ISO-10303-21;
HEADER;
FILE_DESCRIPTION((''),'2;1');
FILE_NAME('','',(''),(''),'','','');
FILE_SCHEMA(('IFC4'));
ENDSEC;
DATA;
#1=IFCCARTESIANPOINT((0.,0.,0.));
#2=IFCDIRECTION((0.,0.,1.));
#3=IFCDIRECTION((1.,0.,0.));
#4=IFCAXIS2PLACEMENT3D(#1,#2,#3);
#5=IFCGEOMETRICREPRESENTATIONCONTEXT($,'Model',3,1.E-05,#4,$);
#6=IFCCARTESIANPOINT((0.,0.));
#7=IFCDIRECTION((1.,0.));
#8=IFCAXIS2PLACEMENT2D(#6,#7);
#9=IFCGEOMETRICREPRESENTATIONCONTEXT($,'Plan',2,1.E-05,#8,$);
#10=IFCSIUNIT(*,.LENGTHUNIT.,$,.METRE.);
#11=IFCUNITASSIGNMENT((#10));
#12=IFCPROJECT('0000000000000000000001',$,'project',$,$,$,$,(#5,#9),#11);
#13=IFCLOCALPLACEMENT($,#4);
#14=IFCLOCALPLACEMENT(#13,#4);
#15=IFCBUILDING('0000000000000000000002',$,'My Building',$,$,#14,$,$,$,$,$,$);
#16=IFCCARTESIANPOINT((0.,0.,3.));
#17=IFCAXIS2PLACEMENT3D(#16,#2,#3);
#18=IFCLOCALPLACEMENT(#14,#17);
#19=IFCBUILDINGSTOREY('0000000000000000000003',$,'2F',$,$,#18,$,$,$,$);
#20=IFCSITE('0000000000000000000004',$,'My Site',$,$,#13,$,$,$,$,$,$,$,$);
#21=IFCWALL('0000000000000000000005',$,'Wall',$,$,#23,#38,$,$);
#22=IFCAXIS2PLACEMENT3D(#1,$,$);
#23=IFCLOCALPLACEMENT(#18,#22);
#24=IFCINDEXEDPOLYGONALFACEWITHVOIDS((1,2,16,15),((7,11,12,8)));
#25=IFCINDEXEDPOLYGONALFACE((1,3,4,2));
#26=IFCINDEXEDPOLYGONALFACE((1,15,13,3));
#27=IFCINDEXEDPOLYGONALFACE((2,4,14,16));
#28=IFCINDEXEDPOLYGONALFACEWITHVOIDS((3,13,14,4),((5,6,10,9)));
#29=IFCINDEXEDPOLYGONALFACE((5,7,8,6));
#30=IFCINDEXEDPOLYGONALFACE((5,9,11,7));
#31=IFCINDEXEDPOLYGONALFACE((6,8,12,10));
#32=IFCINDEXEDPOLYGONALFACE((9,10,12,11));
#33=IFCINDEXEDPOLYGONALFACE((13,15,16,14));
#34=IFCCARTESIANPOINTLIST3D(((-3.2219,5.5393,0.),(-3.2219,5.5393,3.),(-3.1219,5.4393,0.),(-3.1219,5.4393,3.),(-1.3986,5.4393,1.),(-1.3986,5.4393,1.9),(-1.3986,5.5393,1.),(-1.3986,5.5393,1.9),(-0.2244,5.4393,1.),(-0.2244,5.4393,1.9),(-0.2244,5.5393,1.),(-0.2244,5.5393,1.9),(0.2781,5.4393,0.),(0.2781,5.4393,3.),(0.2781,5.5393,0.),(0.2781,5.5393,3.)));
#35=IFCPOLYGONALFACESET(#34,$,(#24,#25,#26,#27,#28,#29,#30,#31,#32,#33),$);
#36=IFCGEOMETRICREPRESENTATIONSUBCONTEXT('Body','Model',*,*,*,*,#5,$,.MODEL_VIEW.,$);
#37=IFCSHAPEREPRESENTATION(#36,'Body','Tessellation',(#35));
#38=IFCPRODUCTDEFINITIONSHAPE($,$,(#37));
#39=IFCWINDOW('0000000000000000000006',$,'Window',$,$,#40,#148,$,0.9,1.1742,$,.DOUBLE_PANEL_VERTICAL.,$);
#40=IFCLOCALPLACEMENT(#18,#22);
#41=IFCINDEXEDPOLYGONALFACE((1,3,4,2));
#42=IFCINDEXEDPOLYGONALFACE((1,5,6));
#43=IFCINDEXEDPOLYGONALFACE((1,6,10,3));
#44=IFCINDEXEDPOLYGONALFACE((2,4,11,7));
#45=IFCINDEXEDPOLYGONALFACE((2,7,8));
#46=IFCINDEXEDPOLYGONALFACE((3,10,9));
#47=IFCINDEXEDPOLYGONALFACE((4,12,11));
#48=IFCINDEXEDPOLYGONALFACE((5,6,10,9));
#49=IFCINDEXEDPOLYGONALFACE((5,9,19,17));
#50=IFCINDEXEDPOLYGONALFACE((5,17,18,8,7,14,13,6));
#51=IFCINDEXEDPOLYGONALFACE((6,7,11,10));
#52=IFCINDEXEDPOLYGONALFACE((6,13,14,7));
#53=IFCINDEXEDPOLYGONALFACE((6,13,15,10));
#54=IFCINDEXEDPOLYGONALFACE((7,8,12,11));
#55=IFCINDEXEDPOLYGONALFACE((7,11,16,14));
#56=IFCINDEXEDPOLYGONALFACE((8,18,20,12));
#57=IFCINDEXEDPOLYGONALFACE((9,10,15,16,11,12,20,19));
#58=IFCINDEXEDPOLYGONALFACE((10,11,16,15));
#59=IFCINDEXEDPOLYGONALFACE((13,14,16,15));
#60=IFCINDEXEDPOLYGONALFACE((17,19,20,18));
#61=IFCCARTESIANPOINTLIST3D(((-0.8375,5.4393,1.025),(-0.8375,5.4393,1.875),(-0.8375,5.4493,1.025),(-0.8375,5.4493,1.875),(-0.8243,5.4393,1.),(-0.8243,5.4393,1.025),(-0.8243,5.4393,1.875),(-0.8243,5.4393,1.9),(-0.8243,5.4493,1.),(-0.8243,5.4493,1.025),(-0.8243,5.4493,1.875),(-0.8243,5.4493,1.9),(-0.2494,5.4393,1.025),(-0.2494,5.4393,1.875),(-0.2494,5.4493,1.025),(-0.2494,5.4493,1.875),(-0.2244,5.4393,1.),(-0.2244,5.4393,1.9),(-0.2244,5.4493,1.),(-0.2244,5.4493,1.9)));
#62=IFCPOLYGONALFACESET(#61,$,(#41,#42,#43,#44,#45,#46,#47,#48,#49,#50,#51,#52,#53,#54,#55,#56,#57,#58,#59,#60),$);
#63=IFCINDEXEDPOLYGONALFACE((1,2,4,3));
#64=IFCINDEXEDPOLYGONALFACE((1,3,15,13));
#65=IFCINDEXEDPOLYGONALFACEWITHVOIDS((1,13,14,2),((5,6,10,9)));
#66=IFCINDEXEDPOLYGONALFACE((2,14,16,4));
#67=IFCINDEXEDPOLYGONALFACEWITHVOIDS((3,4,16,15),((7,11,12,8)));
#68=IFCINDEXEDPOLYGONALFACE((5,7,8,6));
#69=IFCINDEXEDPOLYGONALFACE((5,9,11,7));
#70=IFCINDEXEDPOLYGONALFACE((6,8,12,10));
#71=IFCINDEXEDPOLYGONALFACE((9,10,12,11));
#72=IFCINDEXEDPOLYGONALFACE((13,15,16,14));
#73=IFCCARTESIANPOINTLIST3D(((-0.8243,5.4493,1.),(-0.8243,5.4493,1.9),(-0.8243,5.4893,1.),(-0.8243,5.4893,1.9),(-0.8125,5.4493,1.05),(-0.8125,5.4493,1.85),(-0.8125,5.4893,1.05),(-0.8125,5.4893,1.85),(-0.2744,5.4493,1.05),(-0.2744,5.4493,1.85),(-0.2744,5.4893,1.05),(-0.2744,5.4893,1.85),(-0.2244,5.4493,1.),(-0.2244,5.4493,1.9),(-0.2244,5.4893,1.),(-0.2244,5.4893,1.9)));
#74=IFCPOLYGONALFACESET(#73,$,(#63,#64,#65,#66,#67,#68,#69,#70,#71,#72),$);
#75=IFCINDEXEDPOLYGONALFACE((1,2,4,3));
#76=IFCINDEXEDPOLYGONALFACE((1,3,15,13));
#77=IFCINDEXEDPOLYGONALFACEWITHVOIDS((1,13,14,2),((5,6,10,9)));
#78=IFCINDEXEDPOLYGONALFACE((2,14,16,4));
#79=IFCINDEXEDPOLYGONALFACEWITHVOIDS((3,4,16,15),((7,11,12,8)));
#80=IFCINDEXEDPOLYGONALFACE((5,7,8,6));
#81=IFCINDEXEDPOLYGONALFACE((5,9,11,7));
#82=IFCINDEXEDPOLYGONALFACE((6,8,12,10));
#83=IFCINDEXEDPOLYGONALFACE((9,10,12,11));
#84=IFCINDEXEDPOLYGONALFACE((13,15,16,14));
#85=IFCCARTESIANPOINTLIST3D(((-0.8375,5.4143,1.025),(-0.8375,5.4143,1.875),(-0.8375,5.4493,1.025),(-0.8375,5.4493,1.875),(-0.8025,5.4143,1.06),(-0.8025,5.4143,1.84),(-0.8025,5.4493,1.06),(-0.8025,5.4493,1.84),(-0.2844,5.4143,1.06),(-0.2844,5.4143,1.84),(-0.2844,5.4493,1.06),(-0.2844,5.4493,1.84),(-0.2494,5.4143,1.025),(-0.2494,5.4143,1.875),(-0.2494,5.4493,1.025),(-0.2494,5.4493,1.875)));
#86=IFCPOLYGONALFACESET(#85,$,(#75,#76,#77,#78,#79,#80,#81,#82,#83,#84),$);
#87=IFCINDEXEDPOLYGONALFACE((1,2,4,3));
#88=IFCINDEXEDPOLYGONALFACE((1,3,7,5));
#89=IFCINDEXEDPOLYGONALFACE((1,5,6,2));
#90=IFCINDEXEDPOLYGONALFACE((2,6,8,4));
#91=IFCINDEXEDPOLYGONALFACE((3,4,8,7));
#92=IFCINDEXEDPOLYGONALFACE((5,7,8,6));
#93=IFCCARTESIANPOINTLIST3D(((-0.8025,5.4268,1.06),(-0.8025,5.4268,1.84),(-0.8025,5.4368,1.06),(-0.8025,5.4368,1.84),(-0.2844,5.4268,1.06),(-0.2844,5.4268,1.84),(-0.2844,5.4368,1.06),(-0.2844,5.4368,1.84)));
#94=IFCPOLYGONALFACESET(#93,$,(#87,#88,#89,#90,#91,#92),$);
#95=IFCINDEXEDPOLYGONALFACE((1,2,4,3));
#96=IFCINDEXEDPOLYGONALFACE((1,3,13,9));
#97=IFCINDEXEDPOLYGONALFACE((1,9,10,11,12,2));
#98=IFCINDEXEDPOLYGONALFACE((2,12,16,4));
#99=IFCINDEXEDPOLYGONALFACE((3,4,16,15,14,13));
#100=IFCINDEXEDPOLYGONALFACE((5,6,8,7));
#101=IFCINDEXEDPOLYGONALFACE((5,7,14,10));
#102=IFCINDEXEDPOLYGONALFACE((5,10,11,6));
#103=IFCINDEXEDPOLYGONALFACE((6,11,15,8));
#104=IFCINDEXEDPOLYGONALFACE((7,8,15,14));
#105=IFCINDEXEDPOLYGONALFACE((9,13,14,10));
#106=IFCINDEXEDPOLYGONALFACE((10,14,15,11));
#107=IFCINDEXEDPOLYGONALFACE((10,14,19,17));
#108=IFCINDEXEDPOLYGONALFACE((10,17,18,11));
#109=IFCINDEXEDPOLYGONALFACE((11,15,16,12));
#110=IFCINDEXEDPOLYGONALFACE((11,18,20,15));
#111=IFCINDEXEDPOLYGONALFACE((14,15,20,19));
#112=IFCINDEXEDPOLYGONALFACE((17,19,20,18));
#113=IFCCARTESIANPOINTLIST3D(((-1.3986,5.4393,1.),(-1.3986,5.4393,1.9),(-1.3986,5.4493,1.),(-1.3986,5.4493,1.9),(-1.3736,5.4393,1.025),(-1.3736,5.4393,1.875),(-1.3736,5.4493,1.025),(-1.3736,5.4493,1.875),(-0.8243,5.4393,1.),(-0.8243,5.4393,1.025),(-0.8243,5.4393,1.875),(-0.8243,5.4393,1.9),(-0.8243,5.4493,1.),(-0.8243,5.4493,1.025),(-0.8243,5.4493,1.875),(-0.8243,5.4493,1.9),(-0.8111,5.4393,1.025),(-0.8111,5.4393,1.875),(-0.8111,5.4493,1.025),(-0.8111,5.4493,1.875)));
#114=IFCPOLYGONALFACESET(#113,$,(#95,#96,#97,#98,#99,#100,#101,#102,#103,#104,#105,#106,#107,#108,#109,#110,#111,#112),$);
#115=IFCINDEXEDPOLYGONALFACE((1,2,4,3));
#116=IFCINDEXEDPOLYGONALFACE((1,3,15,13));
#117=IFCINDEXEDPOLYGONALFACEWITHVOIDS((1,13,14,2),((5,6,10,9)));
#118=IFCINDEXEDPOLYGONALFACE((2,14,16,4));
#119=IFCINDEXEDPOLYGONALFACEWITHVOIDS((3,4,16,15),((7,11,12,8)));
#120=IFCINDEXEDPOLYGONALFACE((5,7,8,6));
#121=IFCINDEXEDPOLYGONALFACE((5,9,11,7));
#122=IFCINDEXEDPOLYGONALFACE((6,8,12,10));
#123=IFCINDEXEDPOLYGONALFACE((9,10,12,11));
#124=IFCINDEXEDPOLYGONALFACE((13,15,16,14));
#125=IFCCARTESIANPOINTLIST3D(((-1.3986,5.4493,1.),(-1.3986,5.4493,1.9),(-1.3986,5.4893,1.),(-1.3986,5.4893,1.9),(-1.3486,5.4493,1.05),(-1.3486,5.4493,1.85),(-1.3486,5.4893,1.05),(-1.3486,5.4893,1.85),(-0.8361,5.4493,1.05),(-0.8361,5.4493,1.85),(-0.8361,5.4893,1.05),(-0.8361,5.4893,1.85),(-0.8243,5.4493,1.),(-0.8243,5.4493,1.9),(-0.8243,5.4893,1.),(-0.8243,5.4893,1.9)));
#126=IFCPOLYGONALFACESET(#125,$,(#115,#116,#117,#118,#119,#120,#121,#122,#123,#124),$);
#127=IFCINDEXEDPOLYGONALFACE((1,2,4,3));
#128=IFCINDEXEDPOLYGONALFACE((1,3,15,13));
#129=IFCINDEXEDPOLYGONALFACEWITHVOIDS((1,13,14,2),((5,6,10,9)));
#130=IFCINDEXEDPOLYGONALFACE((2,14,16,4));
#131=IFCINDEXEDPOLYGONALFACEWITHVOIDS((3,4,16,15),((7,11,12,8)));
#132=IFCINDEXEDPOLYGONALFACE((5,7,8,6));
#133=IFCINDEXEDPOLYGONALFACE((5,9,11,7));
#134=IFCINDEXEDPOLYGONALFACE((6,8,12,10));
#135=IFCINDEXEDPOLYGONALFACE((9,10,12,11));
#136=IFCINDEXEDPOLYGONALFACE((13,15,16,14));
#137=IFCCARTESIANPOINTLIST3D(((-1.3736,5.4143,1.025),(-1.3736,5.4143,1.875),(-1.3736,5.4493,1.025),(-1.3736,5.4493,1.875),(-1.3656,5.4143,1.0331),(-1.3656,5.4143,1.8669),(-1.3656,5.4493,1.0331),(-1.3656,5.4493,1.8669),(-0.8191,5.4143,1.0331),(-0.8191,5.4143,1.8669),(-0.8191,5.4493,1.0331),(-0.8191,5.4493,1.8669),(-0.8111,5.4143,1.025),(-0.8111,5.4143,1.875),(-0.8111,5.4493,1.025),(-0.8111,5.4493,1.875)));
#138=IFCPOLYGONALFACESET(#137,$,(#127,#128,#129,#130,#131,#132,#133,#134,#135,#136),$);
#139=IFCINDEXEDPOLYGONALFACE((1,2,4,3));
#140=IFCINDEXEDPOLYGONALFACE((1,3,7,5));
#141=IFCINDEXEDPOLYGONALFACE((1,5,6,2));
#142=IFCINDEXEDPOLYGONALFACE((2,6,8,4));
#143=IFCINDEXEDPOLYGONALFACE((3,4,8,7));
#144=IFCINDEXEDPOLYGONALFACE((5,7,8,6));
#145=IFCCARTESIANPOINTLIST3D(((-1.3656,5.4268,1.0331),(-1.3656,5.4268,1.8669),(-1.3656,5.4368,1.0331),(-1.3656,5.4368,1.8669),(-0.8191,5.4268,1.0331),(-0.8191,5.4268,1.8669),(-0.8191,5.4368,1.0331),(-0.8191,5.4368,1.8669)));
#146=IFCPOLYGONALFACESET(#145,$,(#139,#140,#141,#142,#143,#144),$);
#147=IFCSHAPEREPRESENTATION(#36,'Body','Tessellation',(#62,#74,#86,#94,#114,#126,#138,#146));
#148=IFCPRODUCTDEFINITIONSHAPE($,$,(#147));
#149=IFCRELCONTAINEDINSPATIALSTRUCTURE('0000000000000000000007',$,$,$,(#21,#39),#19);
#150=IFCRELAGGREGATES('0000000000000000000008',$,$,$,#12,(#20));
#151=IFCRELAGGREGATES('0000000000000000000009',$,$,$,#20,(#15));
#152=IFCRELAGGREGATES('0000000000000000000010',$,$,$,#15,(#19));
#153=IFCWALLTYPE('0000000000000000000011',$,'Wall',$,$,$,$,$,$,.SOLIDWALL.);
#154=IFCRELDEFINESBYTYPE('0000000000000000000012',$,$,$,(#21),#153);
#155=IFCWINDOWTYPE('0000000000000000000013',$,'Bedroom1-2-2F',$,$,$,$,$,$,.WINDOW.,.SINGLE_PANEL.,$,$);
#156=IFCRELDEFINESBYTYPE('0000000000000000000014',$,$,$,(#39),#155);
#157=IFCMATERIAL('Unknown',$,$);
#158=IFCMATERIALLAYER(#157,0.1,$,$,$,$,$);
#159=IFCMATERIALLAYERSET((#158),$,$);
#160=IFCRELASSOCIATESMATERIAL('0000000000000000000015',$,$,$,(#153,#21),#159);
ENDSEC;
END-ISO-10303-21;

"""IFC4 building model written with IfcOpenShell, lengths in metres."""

from ifc_helpers import new_model, entity, si_unit, frame, origin_with_axes, origin_2d_with_axis, place, context, subcontext, project, spatial, line, indexed_curve, outline, extrude, shape, source, transform, mapped, material, layer, layer_set, layer_usage, type_object, type_shapes, element, fill, save


model = new_model("IFC4")

# Units and contexts
model_context = context("Model", 3, precision=1e-05, world=origin_with_axes())
plan_context = context("Plan", 2, precision=1e-05, world=origin_2d_with_axis())
body_context_1 = subcontext(model_context, "Body", "Model", "MODEL_VIEW")
body_context_2 = subcontext(plan_context, "Body", "Plan", "PLAN_VIEW")
ifc_project = project(units=[si_unit("LENGTHUNIT", "METRE")], contexts=[model_context, plan_context])

# Site, building, storey
site_placement = place(None, origin_with_axes())
site = spatial("IfcSite", under=ifc_project, at=site_placement, Name="My Site")
building_placement = place(site_placement, origin_with_axes())
building = spatial("IfcBuilding", under=site, at=building_placement, Name="My Building")
storey_placement = place(building_placement, frame((0.0, 0.0, 3.0), z_axis=(0.0, 0.0, 1.0), x_axis=(1.0, 0.0, 0.0)))
storey = spatial("IfcBuildingStorey", under=building, at=storey_placement, Name="2F")

# Shared definitions
ifc_material = material(Name="Unknown")

# Shared definitions
ifc_layer_1 = layer(ifc_material, 0.1)
ifc_layer_set_1 = layer_set([ifc_layer_1])
wall_type = type_object("IfcWallType", Name="Wall", PredefinedType="SOLIDWALL", material=ifc_layer_set_1)

# Wall, opening, window
ifc_layer_usage_1 = layer_usage(ifc_layer_set_1, "AXIS2", "POSITIVE", 0.0)
wall_1_placement = place(storey_placement, frame((0.2781, 5.5393, 0.0), z_axis=(0.0, 0.0, 1.0), x_axis=(-1.0, 0.0, 0.0)))
wall_1 = element("IfcWall", 1, at=wall_1_placement, inside=storey, type_object=wall_type, material=ifc_layer_usage_1, Name="Wall", context=body_context_1, shape_type="SweptSolid", body=[
    extrude(outline(indexed_curve([(0.0, 0.0), (0.0, 0.1), (3.4, 0.1), (3.5, 0.0)], segments=[line(1, 2, 3, 4, 1)])), origin_with_axes(), (0.0, 0.0, 1.0), 3.0),
])
shared_shape_1 = source(origin_with_axes(), body_context_1, "Body", "SweptSolid", [
    extrude(outline(indexed_curve([(0.0, 0.0), (1.1742, 0.0), (1.1742, 0.9), (0.0, 0.9)], segments=[line(1, 2, 3, 4, 1)])), frame((0.0, -0.6, 0.0), z_axis=(0.0, -1.0, 0.0), x_axis=(1.0, 0.0, 0.0)), (0.0, 0.0, -1.0), 1.2),
])
opening_1_placement = place(wall_1_placement, frame((0.5025, 0.0, 1.0), z_axis=(0.0, 0.0, 1.0), x_axis=(1.0, 0.0, 0.0)))
opening_1 = element("IfcOpeningElement", 2, at=opening_1_placement, cuts=wall_1, PredefinedType="OPENING", context=body_context_1, shape_type="MappedRepresentation", body=[
    mapped(shared_shape_1, transform((0.0, 0.0, 0.0), x_axis=(1.0, 0.0, 0.0), y_axis=(0.0, 1.0, 0.0), z_axis=(0.0, 0.0, 1.0), scale=1.0)),
])
window_type_1 = type_object("IfcWindowType", Name="Bedroom1-2-2F", PartitioningType="SINGLE_PANEL", PredefinedType="WINDOW")
shared_shape_2 = source(origin_with_axes(), body_context_1, "Body", "SweptSolid", [
    extrude(outline(indexed_curve([(0.0, 0.0), (0.5999, 0.0), (0.5999, 0.9), (0.0, 0.9)], segments=[line(1, 2, 3, 4, 1)]), holes=[indexed_curve([(0.025, 0.025), (0.6131, 0.025), (0.6131, 0.875), (0.025, 0.875)], segments=[line(1, 2, 3, 4, 1)])]), frame((0.0, 0.09, 0.0), z_axis=(0.0, -1.0, 0.0), x_axis=(1.0, 0.0, 0.0)), (0.0, 0.0, -1.0), 0.01),
    extrude(outline(indexed_curve([(0.0, 0.0), (0.5999, 0.0), (0.5999, 0.9), (0.0, 0.9)], segments=[line(1, 2, 3, 4, 1)]), holes=[indexed_curve([(0.05, 0.05), (0.5881, 0.05), (0.5881, 0.85), (0.05, 0.85)], segments=[line(1, 2, 3, 4, 1)])]), frame((0.0, 0.05, 0.0), z_axis=(0.0, -1.0, 0.0), x_axis=(1.0, 0.0, 0.0)), (0.0, 0.0, -1.0), 0.04),
    extrude(outline(indexed_curve([(0.0, 0.0), (0.5881, 0.0), (0.5881, 0.85), (0.0, 0.85)], segments=[line(1, 2, 3, 4, 1)]), holes=[indexed_curve([(0.035, 0.035), (0.5531, 0.035), (0.5531, 0.815), (0.035, 0.815)], segments=[line(1, 2, 3, 4, 1)])]), frame((0.025, 0.09, 0.025), z_axis=(0.0, -1.0, 0.0), x_axis=(1.0, 0.0, 0.0)), (0.0, 0.0, -1.0), 0.035),
    extrude(outline(indexed_curve([(0.035, 0.035), (0.5531, 0.035), (0.5531, 0.815), (0.035, 0.815)], segments=[line(1, 2, 3, 4, 1)])), frame((0.025, 0.1025, 0.025), z_axis=(0.0, -1.0, 0.0), x_axis=(1.0, 0.0, 0.0)), (0.0, 0.0, -1.0), 0.01),
    extrude(outline(indexed_curve([(0.0, 0.0), (0.5744, 0.0), (0.5744, 0.9), (0.0, 0.9)], segments=[line(1, 2, 3, 4, 1)]), holes=[indexed_curve([(-0.0132, 0.025), (0.5494, 0.025), (0.5494, 0.875), (-0.0132, 0.875)], segments=[line(1, 2, 3, 4, 1)])]), frame((0.5999, 0.09, 0.0), z_axis=(0.0, -1.0, 0.0), x_axis=(1.0, 0.0, 0.0)), (0.0, 0.0, -1.0), 0.01),
    extrude(outline(indexed_curve([(0.0, 0.0), (0.5744, 0.0), (0.5744, 0.9), (0.0, 0.9)], segments=[line(1, 2, 3, 4, 1)]), holes=[indexed_curve([(0.0118, 0.05), (0.5244, 0.05), (0.5244, 0.85), (0.0118, 0.85)], segments=[line(1, 2, 3, 4, 1)])]), frame((0.5999, 0.05, 0.0), z_axis=(0.0, -1.0, 0.0), x_axis=(1.0, 0.0, 0.0)), (0.0, 0.0, -1.0), 0.04),
    extrude(outline(indexed_curve([(0.0, 0.0), (0.5626, 0.0), (0.5626, 0.85), (0.0, 0.85)], segments=[line(1, 2, 3, 4, 1)]), holes=[indexed_curve([(0.0081, 0.0081), (0.5545, 0.0081), (0.5545, 0.8419), (0.0081, 0.8419)], segments=[line(1, 2, 3, 4, 1)])]), frame((0.5866, 0.09, 0.025), z_axis=(0.0, -1.0, 0.0), x_axis=(1.0, 0.0, 0.0)), (0.0, 0.0, -1.0), 0.035),
    extrude(outline(indexed_curve([(0.0081, 0.0081), (0.5545, 0.0081), (0.5545, 0.8419), (0.0081, 0.8419)], segments=[line(1, 2, 3, 4, 1)])), frame((0.5866, 0.1025, 0.025), z_axis=(0.0, -1.0, 0.0), x_axis=(1.0, 0.0, 0.0)), (0.0, 0.0, -1.0), 0.01),
])
shared_shape_3 = source(origin_with_axes(), body_context_2, "Body", "Curve2D", [
    entity("IfcIndexedPolyCurve", entity("IfcCartesianPointList2D", [[0.05, 0.05], [0.5881, 0.05]])),
    entity("IfcIndexedPolyCurve", entity("IfcCartesianPointList2D", [[0.0, 0.1], [0.025, 0.1], [0.025, 0.09], [0.05, 0.09], [0.05, 0.05], [0.0, 0.05]]), [entity("IfcLineIndex", [1, 2, 3, 4, 5, 6, 1])]),
    entity("IfcIndexedPolyCurve", entity("IfcCartesianPointList2D", [[0.5999, 0.1], [0.6131, 0.1], [0.6131, 0.09], [0.5881, 0.09], [0.5881, 0.05], [0.5999, 0.05]])),
    entity("IfcIndexedPolyCurve", entity("IfcCartesianPointList2D", [[0.025, 0.09], [0.06, 0.09], [0.06, 0.125], [0.025, 0.125]]), [entity("IfcLineIndex", [1, 2, 3, 4, 1])]),
    entity("IfcIndexedPolyCurve", entity("IfcCartesianPointList2D", [[0.6131, 0.09], [0.5781, 0.09], [0.5781, 0.125], [0.6131, 0.125]]), [entity("IfcLineIndex", [1, 2, 3, 4, 1])]),
    entity("IfcIndexedPolyCurve", entity("IfcCartesianPointList2D", [[0.06, 0.09], [0.5781, 0.09]])),
    entity("IfcIndexedPolyCurve", entity("IfcCartesianPointList2D", [[0.06, 0.125], [0.5781, 0.125]])),
    entity("IfcIndexedPolyCurve", entity("IfcCartesianPointList2D", [[0.06, 0.1075], [0.5781, 0.1075]])),
    entity("IfcIndexedPolyCurve", entity("IfcCartesianPointList2D", [[0.6116, 0.05], [1.1242, 0.05]])),
    entity("IfcIndexedPolyCurve", entity("IfcCartesianPointList2D", [[0.5999, 0.1], [0.5866, 0.1], [0.5866, 0.09], [0.6116, 0.09], [0.6116, 0.05], [0.5999, 0.05]])),
    entity("IfcIndexedPolyCurve", entity("IfcCartesianPointList2D", [[1.1742, 0.1], [1.1492, 0.1], [1.1492, 0.09], [1.1242, 0.09], [1.1242, 0.05], [1.1742, 0.05]]), [entity("IfcLineIndex", [1, 2, 3, 4, 5, 6, 1])]),
    entity("IfcIndexedPolyCurve", entity("IfcCartesianPointList2D", [[0.5866, 0.09], [0.5947, 0.09], [0.5947, 0.125], [0.5866, 0.125]]), [entity("IfcLineIndex", [1, 2, 3, 4, 1])]),
    entity("IfcIndexedPolyCurve", entity("IfcCartesianPointList2D", [[1.1492, 0.09], [1.1412, 0.09], [1.1412, 0.125], [1.1492, 0.125]]), [entity("IfcLineIndex", [1, 2, 3, 4, 1])]),
    entity("IfcIndexedPolyCurve", entity("IfcCartesianPointList2D", [[0.5947, 0.09], [1.1412, 0.09]])),
    entity("IfcIndexedPolyCurve", entity("IfcCartesianPointList2D", [[0.5947, 0.125], [1.1412, 0.125]])),
    entity("IfcIndexedPolyCurve", entity("IfcCartesianPointList2D", [[0.5947, 0.1075], [1.1412, 0.1075]])),
])
type_shapes(window_type_1, [shared_shape_2, shared_shape_3])
window_1_placement = place(opening_1_placement, frame((0.0, 0.0, 0.0), z_axis=(0.0, 0.0, 1.0), x_axis=(1.0, 0.0, 0.0)))
window_1 = element("IfcWindow", 3, at=window_1_placement, inside=storey, type_object=window_type_1, Name="Window", OverallHeight=0.9, OverallWidth=1.1742, PartitioningType="DOUBLE_PANEL_VERTICAL", shapes=[
    shape(body_context_1, "Body", "MappedRepresentation", [mapped(shared_shape_2, transform((0.0, 0.0, 0.0), x_axis=(1.0, 0.0, 0.0), y_axis=(0.0, 1.0, 0.0), z_axis=(0.0, 0.0, 1.0), scale=1.0))]),
    shape(body_context_2, "Body", "MappedRepresentation", [mapped(shared_shape_3, transform((0.0, 0.0, 0.0), x_axis=(1.0, 0.0, 0.0), y_axis=(0.0, 1.0, 0.0), z_axis=(0.0, 0.0, 1.0), scale=1.0))]),
])
fill(opening_1, window_1)

save(model, "model.ifc")
